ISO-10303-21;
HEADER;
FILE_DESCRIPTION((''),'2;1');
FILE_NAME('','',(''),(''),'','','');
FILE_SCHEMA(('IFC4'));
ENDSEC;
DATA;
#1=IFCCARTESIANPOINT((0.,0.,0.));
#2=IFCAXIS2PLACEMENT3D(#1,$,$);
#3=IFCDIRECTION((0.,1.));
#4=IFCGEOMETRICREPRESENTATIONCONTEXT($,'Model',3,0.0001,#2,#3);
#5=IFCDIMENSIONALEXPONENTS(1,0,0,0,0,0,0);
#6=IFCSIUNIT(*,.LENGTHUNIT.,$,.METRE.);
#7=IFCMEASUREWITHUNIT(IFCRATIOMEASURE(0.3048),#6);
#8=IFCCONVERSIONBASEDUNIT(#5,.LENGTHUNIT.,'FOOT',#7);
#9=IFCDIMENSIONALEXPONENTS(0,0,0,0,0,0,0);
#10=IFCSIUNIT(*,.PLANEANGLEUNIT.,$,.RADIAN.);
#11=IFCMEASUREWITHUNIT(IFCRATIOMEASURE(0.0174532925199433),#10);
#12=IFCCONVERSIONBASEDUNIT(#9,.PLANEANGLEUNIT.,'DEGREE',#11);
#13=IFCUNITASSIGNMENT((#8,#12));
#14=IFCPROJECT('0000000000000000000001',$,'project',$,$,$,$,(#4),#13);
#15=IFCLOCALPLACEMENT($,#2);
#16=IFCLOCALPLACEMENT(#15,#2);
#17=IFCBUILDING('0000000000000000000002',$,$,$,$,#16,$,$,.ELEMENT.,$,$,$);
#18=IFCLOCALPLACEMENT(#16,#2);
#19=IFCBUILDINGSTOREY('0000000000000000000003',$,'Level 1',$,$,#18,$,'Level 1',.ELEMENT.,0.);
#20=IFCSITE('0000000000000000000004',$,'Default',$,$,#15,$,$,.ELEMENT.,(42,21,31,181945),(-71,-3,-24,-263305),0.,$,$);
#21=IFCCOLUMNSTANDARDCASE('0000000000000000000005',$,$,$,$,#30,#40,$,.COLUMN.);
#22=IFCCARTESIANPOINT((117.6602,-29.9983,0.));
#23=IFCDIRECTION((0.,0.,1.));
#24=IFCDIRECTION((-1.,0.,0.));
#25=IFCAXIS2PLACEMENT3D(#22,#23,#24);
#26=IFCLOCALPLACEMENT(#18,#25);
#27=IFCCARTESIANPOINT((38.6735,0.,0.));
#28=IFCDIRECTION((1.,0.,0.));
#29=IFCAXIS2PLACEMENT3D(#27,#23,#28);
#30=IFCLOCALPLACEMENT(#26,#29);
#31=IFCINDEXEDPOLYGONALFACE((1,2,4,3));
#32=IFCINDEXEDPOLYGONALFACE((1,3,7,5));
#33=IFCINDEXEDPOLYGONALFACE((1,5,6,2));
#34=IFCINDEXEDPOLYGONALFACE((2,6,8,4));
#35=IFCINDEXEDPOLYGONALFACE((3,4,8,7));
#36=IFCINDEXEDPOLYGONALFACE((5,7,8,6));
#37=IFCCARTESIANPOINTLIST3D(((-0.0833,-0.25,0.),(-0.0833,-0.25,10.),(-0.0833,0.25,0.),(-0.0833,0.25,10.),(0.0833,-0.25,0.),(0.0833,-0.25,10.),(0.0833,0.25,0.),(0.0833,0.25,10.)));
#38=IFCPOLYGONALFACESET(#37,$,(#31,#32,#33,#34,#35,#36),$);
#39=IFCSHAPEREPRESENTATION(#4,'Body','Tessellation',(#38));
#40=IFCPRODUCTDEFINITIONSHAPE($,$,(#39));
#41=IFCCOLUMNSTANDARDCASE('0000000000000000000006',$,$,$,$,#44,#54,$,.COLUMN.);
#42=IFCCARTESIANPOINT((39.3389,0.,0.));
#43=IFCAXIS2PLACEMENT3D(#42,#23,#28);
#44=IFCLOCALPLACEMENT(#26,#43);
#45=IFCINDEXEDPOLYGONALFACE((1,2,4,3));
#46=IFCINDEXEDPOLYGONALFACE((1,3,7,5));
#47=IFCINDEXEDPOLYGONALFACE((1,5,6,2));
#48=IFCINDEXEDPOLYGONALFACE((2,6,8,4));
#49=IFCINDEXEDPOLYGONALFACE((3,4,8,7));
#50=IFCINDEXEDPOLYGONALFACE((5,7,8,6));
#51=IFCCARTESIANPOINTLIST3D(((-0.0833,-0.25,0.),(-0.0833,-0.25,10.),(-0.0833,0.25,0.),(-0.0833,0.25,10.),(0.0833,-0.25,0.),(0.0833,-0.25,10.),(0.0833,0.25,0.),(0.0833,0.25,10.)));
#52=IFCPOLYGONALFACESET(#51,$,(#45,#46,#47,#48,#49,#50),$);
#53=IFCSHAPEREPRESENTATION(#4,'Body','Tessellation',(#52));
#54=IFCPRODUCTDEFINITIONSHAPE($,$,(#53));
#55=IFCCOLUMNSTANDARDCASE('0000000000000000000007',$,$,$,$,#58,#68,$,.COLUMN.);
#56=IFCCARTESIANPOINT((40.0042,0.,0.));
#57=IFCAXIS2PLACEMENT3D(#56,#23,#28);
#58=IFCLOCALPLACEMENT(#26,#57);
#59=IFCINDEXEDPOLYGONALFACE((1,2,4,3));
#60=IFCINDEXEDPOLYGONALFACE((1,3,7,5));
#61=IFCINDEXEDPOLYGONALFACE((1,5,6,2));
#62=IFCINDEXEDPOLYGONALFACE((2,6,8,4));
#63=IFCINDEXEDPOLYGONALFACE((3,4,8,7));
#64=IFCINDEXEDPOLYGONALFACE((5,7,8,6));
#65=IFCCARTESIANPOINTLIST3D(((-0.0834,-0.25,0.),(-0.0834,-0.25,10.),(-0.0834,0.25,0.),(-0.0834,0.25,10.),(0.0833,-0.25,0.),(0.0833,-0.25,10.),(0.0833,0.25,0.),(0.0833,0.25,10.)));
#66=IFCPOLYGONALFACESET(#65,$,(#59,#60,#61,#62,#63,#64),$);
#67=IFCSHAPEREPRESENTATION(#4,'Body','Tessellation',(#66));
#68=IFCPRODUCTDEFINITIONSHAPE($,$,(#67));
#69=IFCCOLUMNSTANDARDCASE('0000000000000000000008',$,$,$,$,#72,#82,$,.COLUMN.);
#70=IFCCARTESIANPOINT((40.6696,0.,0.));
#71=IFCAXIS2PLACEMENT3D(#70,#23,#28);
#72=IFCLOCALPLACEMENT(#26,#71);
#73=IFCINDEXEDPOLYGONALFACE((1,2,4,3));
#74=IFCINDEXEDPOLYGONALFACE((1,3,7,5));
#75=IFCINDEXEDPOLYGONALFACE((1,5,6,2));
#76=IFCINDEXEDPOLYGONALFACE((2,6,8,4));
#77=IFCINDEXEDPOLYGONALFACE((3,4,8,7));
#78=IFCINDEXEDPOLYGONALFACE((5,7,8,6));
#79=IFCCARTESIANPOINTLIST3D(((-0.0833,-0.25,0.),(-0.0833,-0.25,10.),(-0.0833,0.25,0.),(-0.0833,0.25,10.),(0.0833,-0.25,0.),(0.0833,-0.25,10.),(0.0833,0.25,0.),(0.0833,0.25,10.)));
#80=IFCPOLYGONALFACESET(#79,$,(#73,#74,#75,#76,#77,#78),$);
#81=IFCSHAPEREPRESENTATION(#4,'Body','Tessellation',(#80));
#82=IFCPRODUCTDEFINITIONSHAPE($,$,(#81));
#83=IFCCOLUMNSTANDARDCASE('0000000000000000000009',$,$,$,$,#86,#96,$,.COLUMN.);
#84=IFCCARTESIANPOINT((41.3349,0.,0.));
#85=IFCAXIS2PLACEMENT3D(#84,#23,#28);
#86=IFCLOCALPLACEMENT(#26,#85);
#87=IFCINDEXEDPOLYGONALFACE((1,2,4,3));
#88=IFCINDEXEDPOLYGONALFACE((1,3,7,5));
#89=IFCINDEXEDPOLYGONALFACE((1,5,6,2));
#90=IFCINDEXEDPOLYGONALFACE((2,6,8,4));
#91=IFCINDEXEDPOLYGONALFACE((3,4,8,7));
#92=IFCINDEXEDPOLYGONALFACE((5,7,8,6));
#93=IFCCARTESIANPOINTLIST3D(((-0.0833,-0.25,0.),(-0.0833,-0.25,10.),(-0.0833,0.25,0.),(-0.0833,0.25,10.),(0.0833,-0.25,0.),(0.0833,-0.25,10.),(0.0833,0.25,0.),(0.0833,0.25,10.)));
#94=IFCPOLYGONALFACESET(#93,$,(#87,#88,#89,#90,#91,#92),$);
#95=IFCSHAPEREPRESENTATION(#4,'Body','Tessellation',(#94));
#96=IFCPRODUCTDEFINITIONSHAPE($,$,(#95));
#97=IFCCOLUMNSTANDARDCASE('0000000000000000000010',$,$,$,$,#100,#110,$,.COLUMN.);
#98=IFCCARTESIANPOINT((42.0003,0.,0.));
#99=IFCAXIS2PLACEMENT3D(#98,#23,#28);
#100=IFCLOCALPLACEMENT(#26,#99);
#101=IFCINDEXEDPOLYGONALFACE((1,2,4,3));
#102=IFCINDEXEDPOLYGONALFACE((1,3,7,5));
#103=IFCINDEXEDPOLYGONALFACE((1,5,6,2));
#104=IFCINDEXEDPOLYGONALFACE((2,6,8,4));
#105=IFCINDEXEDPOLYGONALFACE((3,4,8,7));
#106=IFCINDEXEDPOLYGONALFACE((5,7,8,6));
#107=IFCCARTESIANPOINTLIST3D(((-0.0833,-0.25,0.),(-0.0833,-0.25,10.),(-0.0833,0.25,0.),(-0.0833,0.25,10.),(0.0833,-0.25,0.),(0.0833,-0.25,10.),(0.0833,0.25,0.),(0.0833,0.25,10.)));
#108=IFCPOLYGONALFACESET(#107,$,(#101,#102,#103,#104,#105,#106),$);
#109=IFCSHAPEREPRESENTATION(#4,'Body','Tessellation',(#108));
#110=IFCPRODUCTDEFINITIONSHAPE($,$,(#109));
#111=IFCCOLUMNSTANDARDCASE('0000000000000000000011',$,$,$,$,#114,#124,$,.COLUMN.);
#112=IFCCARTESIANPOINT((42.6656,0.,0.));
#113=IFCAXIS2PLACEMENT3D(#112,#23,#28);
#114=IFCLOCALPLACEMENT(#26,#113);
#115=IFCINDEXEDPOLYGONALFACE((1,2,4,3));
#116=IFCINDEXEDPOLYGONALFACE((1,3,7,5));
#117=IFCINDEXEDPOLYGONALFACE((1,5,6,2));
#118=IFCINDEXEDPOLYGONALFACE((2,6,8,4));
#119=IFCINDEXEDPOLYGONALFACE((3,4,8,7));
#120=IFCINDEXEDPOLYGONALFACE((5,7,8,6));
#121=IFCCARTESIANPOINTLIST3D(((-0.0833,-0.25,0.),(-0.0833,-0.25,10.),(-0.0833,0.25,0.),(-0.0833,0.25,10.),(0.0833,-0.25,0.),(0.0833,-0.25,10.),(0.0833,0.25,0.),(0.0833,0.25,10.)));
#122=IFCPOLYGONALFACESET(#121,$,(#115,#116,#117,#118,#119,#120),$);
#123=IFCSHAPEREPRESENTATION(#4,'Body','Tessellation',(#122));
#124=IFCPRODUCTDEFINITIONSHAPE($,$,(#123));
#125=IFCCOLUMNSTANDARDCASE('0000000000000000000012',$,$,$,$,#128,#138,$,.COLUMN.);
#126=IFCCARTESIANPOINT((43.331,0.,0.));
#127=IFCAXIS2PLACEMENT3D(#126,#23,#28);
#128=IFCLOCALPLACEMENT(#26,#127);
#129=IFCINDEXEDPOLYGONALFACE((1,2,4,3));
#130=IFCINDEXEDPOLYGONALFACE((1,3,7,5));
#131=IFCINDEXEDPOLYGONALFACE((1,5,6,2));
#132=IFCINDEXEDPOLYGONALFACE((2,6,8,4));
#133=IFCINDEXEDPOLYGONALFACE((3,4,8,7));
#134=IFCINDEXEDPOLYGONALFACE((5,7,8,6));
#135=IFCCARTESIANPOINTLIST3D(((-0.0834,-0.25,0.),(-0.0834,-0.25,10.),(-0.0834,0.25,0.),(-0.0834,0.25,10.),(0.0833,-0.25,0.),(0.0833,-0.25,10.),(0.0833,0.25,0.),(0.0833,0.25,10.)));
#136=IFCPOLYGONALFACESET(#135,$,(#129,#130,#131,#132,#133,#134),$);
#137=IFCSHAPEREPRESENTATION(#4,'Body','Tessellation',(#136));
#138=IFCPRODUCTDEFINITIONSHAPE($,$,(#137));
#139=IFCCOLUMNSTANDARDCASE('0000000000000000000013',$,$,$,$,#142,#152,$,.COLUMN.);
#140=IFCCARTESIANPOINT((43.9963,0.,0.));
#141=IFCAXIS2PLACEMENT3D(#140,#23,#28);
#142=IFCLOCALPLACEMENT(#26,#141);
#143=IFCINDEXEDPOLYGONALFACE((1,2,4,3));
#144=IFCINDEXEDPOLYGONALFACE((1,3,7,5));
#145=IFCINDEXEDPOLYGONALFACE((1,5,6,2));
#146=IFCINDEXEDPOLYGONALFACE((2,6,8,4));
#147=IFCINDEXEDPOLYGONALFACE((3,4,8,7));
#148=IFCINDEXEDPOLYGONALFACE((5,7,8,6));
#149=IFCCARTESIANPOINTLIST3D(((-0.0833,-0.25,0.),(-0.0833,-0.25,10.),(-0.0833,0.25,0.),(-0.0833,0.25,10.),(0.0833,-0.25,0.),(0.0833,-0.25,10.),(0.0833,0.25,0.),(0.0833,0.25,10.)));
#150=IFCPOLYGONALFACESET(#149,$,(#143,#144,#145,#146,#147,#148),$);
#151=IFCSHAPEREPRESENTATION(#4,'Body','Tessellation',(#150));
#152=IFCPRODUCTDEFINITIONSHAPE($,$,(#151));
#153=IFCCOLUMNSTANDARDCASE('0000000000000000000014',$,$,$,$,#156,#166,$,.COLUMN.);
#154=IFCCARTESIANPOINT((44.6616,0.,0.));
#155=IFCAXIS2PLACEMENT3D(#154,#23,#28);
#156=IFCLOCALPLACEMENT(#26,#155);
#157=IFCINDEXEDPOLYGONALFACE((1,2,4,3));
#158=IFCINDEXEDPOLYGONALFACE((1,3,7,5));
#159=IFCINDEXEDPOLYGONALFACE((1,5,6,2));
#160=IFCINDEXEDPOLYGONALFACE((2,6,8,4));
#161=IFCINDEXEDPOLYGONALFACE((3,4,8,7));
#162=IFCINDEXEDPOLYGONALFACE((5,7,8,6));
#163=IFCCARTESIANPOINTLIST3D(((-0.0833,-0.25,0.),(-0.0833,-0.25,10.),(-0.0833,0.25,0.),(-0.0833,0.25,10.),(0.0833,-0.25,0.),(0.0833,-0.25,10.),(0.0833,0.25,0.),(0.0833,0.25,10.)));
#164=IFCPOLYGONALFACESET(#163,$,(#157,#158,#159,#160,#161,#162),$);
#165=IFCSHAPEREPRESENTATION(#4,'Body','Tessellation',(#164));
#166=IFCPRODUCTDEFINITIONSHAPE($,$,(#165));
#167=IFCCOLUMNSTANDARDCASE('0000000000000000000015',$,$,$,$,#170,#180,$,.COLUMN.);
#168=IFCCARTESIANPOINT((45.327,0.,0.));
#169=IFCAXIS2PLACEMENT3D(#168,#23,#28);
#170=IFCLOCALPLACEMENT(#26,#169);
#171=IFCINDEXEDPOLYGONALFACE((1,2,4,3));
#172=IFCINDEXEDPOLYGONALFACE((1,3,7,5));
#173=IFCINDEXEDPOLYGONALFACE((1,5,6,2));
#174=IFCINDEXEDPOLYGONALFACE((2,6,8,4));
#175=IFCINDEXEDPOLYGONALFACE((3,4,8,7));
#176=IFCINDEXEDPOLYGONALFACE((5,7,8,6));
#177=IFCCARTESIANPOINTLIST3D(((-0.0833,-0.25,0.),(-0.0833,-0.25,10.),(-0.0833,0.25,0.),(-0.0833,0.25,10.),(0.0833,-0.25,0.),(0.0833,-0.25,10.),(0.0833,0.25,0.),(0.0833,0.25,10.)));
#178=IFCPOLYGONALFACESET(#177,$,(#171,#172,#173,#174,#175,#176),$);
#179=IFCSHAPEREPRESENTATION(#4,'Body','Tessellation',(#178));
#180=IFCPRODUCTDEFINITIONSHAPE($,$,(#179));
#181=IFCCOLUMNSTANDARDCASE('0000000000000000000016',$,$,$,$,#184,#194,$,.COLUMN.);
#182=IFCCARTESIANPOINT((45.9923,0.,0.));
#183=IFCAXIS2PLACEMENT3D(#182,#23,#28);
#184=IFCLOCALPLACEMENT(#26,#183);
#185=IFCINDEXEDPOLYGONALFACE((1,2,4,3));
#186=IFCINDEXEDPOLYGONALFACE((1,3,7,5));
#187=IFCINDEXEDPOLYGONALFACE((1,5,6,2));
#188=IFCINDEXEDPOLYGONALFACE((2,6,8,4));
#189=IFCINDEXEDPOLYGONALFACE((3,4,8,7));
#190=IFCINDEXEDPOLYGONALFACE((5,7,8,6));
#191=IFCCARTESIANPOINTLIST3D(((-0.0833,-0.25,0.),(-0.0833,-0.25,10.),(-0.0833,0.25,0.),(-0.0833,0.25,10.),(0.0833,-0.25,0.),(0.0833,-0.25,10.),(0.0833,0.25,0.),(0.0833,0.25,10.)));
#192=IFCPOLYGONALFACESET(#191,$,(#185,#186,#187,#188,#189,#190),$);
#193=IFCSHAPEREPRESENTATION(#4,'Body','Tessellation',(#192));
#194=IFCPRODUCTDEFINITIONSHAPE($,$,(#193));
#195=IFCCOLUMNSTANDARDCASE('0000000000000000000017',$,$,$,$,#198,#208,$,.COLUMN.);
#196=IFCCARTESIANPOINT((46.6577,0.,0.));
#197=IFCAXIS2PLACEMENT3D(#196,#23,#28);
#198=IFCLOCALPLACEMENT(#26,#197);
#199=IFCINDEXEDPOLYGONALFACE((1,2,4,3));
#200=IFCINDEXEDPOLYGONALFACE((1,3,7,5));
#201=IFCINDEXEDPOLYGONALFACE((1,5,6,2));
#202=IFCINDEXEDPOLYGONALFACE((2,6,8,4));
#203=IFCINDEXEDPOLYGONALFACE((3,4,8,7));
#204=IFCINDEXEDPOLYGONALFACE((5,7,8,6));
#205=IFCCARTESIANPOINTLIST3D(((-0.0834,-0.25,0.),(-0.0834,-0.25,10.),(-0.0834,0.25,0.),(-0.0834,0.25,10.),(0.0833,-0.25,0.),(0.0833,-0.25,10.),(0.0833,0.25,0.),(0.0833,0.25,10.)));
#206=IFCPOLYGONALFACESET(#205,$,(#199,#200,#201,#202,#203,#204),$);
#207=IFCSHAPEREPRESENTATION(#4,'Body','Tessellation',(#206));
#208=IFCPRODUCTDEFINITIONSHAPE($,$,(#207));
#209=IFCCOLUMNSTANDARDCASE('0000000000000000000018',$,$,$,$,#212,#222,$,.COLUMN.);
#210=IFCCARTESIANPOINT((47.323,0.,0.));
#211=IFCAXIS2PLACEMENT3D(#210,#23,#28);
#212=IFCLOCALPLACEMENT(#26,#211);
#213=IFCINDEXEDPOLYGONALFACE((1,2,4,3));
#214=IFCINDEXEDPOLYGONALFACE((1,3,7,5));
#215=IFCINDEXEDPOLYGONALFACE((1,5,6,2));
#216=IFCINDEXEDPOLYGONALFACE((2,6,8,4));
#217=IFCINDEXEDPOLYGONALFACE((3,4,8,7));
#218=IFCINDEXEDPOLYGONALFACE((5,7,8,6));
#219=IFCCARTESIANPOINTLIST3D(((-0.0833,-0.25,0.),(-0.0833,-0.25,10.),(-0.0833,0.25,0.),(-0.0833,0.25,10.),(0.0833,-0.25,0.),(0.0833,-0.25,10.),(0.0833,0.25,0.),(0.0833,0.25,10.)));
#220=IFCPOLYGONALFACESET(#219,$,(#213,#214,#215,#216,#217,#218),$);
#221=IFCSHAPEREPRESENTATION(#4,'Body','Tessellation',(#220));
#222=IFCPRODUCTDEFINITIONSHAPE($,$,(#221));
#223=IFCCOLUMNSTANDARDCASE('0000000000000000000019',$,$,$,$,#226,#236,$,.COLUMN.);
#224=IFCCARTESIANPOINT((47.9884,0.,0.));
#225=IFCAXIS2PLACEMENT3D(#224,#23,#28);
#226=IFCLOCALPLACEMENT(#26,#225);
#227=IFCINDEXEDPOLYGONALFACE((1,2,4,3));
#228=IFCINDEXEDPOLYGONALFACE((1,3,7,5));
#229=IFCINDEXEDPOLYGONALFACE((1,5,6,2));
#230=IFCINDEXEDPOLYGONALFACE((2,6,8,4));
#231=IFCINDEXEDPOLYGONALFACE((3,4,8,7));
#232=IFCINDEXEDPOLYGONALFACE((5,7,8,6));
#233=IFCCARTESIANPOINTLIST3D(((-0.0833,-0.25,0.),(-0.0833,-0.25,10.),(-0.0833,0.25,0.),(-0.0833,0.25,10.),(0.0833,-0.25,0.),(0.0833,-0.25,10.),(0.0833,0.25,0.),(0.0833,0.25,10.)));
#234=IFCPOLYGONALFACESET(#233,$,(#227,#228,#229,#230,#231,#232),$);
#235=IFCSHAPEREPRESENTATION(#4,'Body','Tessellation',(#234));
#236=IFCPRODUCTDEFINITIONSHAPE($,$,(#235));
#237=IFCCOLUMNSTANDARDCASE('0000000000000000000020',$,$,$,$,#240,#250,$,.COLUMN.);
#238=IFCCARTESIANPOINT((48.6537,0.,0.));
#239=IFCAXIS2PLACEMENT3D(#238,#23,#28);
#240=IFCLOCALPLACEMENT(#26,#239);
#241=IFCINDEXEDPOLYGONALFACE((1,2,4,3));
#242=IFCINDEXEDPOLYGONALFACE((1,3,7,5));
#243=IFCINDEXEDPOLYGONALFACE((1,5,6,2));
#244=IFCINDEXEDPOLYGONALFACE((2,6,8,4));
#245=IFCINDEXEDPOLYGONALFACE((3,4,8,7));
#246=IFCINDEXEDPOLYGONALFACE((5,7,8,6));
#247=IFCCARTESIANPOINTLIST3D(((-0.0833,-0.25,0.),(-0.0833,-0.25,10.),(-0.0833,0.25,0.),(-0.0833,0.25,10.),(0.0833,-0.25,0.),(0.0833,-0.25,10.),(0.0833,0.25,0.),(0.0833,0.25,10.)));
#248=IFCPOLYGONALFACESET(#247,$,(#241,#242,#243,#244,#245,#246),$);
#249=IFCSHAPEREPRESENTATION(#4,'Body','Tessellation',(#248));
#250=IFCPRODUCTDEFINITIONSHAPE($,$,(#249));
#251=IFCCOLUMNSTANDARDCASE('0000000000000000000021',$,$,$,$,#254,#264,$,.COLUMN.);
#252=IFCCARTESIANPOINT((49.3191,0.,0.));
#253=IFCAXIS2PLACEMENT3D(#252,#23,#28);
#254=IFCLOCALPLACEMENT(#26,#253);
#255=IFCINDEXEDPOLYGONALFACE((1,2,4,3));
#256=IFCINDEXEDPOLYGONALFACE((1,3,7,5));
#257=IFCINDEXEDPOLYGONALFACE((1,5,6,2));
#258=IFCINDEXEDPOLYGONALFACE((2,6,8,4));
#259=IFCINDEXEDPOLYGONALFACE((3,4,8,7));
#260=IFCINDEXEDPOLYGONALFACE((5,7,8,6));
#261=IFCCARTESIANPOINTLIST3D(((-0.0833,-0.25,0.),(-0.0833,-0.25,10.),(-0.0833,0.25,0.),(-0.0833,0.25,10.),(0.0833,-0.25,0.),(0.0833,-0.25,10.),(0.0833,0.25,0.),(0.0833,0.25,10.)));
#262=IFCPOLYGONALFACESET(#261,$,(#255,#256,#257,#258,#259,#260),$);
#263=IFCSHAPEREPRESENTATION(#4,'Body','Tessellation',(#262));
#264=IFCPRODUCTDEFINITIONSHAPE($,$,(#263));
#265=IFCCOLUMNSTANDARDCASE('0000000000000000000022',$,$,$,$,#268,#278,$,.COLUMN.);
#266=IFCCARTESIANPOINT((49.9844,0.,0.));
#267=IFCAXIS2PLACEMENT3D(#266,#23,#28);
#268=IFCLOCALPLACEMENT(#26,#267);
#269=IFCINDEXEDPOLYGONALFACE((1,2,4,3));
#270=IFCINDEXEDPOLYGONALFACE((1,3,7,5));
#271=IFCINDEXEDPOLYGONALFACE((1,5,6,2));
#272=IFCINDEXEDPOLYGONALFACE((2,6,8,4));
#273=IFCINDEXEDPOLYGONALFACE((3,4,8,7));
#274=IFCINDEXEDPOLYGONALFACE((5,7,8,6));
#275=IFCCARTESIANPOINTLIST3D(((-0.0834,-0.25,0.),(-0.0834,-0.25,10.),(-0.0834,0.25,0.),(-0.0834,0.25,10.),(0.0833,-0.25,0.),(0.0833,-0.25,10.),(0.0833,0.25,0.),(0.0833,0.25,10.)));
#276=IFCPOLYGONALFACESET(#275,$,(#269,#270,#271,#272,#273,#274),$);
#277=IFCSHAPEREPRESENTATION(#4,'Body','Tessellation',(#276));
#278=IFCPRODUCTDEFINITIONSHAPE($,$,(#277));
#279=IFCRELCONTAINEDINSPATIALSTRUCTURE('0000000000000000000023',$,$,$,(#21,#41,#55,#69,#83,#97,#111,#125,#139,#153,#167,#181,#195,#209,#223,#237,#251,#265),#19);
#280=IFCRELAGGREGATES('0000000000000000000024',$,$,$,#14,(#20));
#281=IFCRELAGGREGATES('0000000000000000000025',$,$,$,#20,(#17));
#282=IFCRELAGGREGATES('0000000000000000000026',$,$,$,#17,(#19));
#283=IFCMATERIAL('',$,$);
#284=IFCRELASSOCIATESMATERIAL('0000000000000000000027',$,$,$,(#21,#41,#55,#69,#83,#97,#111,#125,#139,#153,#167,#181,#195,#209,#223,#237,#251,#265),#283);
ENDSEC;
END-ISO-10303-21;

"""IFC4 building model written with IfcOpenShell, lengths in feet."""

from ifc_helpers import new_model, entity, si_unit, converted_unit, direction, frame, origin, place, context, project, spatial, rectangle, extrude, material, element, save


model = new_model("IFC4")

# Units and contexts
model_context = context("Model", 3, precision=0.0001, world=origin(), true_north=direction((0.0, 1.0)))
ifc_project = project(units=[converted_unit("LENGTHUNIT", "FOOT", entity("IfcRatioMeasure", 0.3048), si_unit("LENGTHUNIT", "METRE"), dimensions=[1, 0, 0, 0, 0, 0, 0]), converted_unit("PLANEANGLEUNIT", "DEGREE", entity("IfcRatioMeasure", 0.0174532925199433), si_unit("PLANEANGLEUNIT", "RADIAN"), dimensions=[0, 0, 0, 0, 0, 0, 0])], contexts=[model_context])

# Site, building, storey
site_placement = place(None, origin())
site = spatial("IfcSite", under=ifc_project, at=site_placement, Name="Default", CompositionType="ELEMENT", RefLatitude=(42, 21, 31, 181945), RefLongitude=(-71, -3, -24, -263305), RefElevation=0.0)
building_placement = place(site_placement, origin())
building = spatial("IfcBuilding", under=site, at=building_placement, CompositionType="ELEMENT")
storey_placement = place(building_placement, origin())
storey = spatial("IfcBuildingStorey", under=building, at=storey_placement, Name="Level 1", LongName="Level 1", CompositionType="ELEMENT", Elevation=0.0)

# Columns
ifc_material = material(Name="")
placement = place(storey_placement, frame((117.6602, -29.9983, 0.0), z_axis=(0.0, 0.0, 1.0), x_axis=(-1.0, 0.0, 0.0)))
for number, where, z_axis, x_axis in (
    (1, (38.6735, 0.0, 0.0), (0.0, 0.0, 1.0), (1.0, 0.0, 0.0)),
    (2, (39.3389, 0.0, 0.0), (0.0, 0.0, 1.0), (1.0, 0.0, 0.0)),
    (3, (40.0042, 0.0, 0.0), (0.0, 0.0, 1.0), (1.0, 0.0, 0.0)),
    (4, (40.6696, 0.0, 0.0), (0.0, 0.0, 1.0), (1.0, 0.0, 0.0)),
    (5, (41.3349, 0.0, 0.0), (0.0, 0.0, 1.0), (1.0, 0.0, 0.0)),
    (6, (42.0003, 0.0, 0.0), (0.0, 0.0, 1.0), (1.0, 0.0, 0.0)),
    (7, (42.6656, 0.0, 0.0), (0.0, 0.0, 1.0), (1.0, 0.0, 0.0)),
    (8, (43.331, 0.0, 0.0), (0.0, 0.0, 1.0), (1.0, 0.0, 0.0)),
    (9, (43.9963, 0.0, 0.0), (0.0, 0.0, 1.0), (1.0, 0.0, 0.0)),
    (10, (44.6616, 0.0, 0.0), (0.0, 0.0, 1.0), (1.0, 0.0, 0.0)),
    (11, (45.327, 0.0, 0.0), (0.0, 0.0, 1.0), (1.0, 0.0, 0.0)),
    (12, (45.9923, 0.0, 0.0), (0.0, 0.0, 1.0), (1.0, 0.0, 0.0)),
    (13, (46.6577, 0.0, 0.0), (0.0, 0.0, 1.0), (1.0, 0.0, 0.0)),
    (14, (47.323, 0.0, 0.0), (0.0, 0.0, 1.0), (1.0, 0.0, 0.0)),
    (15, (47.9884, 0.0, 0.0), (0.0, 0.0, 1.0), (1.0, 0.0, 0.0)),
    (16, (48.6537, 0.0, 0.0), (0.0, 0.0, 1.0), (1.0, 0.0, 0.0)),
    (17, (49.3191, 0.0, 0.0), (0.0, 0.0, 1.0), (1.0, 0.0, 0.0)),
    (18, (49.9844, 0.0, 0.0), (0.0, 0.0, 1.0), (1.0, 0.0, 0.0)),
):
    element("IfcColumnStandardCase", number, at=place(placement, frame(where, z_axis=z_axis, x_axis=x_axis)), inside=storey, material=ifc_material, PredefinedType="COLUMN", context=model_context, shape_type="SweptSolid", body=[
        extrude(rectangle(XDim=0.1667, YDim=0.5), origin(), (0.0, 0.0, 1.0), 10.0),
    ])

save(model, "model.ifc")
